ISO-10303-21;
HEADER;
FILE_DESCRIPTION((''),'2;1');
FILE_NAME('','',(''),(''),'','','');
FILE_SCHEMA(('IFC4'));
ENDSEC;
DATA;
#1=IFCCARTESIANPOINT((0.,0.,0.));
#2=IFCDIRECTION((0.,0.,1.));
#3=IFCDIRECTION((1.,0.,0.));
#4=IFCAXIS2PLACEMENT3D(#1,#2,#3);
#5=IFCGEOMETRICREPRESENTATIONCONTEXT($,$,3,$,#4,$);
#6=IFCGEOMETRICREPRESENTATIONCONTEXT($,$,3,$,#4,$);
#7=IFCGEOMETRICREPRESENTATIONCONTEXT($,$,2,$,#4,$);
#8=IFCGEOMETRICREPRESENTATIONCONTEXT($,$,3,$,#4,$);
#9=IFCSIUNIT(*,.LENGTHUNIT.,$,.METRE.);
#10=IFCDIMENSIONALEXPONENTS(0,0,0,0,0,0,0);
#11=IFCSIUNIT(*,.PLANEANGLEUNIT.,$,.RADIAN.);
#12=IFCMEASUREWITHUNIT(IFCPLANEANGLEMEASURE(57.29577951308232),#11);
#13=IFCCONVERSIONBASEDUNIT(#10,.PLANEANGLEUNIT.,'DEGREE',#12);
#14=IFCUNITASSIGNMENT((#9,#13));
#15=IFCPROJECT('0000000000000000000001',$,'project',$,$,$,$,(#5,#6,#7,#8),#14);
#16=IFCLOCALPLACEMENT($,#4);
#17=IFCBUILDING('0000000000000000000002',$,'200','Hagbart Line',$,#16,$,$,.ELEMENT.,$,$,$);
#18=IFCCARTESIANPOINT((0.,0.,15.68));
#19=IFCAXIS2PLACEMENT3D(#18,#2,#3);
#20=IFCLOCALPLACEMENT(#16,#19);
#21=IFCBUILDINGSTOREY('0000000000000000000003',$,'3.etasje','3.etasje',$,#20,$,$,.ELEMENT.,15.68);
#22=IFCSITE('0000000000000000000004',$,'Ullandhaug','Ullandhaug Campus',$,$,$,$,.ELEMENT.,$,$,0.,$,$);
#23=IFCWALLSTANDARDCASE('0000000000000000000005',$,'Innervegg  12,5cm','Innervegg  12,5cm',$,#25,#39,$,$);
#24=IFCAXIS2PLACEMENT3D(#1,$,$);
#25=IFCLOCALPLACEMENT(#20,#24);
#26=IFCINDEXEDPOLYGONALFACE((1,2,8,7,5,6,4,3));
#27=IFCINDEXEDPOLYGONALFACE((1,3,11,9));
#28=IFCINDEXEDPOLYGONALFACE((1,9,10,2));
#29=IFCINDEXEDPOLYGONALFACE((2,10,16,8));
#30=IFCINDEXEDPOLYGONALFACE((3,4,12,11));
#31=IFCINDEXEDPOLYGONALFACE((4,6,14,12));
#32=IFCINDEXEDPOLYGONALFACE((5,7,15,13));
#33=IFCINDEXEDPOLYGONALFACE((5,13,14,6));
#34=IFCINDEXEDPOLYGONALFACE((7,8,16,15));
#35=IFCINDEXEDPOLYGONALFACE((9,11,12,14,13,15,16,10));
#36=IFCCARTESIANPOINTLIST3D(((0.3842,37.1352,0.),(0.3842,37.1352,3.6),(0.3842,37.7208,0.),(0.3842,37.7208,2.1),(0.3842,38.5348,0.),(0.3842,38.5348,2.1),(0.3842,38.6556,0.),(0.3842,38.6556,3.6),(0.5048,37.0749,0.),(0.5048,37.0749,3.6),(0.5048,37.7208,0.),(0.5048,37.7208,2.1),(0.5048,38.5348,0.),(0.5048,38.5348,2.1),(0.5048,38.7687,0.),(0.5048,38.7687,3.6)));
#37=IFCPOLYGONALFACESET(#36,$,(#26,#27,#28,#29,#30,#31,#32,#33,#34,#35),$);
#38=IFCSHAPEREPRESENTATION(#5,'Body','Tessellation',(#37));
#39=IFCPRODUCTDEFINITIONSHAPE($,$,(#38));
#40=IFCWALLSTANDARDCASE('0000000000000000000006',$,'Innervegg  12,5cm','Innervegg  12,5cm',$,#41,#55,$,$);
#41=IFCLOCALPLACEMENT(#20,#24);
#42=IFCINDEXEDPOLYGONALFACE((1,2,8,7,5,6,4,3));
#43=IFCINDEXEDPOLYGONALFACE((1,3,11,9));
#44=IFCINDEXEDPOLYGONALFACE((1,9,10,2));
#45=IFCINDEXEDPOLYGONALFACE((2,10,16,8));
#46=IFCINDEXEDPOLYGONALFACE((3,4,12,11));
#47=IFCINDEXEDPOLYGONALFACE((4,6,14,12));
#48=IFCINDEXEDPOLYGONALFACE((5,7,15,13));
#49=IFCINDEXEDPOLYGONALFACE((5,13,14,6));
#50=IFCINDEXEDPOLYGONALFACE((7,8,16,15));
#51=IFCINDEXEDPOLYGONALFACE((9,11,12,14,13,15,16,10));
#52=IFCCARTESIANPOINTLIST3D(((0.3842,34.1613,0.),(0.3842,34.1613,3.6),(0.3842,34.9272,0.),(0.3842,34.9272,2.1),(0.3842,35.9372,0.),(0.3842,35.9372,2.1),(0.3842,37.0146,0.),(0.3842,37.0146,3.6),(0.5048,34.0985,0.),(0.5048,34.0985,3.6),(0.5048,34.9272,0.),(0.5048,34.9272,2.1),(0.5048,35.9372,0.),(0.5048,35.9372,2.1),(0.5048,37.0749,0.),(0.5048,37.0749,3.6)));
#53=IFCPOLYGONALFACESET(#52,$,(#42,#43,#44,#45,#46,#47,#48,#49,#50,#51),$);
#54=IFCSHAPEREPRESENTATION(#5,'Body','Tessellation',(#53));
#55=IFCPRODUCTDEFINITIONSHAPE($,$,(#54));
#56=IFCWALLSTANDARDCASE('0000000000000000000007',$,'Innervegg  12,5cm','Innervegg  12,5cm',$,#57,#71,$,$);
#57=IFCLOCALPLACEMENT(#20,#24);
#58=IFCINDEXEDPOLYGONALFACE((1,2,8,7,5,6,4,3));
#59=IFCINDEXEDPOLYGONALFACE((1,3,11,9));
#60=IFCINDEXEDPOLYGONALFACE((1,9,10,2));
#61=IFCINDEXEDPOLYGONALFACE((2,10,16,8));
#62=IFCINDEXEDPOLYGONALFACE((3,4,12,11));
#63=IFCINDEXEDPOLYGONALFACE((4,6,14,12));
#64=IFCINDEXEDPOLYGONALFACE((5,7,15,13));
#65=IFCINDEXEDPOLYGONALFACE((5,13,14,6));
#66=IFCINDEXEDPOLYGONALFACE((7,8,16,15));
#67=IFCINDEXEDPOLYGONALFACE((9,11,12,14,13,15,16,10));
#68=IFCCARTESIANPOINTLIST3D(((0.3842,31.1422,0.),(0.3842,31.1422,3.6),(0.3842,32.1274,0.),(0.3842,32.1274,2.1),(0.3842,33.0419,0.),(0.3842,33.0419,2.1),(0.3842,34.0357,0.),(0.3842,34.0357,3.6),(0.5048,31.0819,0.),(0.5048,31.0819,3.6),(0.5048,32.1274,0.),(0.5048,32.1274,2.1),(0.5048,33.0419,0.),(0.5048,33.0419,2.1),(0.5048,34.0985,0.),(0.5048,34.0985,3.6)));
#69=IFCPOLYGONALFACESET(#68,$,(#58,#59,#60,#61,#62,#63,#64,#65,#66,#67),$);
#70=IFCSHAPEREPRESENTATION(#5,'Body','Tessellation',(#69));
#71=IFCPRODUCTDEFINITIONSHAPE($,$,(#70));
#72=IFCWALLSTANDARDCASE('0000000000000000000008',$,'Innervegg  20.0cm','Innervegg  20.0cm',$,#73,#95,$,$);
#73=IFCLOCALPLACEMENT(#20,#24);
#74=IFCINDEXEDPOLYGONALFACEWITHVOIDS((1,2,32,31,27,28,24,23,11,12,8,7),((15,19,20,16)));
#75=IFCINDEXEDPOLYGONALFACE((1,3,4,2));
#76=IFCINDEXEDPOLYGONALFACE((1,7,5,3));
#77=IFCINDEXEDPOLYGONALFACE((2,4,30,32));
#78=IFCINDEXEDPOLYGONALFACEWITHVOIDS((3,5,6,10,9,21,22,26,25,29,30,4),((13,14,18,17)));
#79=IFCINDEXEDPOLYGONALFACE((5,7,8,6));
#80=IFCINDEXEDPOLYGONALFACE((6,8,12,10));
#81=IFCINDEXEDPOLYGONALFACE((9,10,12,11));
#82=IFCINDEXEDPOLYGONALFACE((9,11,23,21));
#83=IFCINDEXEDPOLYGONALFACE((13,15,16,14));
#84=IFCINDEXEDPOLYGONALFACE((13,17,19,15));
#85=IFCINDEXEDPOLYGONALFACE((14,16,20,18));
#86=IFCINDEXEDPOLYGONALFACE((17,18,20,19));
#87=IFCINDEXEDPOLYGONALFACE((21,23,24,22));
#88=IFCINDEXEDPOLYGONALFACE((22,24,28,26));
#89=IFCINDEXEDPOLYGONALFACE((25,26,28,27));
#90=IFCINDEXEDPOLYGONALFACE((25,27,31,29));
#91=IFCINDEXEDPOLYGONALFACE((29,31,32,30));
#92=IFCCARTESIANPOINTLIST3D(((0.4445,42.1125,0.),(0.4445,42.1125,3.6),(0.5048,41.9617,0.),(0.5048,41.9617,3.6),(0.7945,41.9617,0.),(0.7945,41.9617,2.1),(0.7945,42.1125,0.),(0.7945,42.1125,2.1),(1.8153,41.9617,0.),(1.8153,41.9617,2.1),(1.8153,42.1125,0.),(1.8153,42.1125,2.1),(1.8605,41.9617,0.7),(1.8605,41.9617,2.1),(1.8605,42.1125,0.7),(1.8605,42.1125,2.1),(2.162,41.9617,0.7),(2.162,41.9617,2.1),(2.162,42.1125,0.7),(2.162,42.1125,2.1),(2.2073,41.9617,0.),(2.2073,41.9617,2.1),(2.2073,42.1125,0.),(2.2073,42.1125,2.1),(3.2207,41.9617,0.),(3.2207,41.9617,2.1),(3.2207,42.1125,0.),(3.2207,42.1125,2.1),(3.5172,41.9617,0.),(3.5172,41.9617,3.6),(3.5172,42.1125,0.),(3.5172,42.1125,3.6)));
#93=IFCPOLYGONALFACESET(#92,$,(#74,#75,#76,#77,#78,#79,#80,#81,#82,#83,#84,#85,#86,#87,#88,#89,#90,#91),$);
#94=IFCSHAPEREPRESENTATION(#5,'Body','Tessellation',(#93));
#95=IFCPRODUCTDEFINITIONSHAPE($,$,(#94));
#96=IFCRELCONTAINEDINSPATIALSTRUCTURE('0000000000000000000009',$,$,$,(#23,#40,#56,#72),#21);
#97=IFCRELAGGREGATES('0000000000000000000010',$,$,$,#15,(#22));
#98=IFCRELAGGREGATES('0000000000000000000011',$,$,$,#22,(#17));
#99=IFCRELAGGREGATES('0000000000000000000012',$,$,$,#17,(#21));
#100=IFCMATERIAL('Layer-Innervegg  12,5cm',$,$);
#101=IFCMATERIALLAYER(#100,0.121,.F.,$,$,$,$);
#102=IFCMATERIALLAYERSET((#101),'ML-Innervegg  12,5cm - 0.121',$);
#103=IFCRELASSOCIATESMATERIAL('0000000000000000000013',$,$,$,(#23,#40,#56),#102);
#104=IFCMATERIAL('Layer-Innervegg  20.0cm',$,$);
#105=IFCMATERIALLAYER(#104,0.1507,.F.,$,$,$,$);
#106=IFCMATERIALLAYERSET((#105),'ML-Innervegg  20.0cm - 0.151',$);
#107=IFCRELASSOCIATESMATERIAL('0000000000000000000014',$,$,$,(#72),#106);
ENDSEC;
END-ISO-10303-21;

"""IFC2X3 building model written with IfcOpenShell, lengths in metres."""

from ifc_helpers import new_model, entity, si_unit, converted_unit, frame, origin_with_axes, place, context, project, spatial, polyline, outline, extrude, material, layer, layer_set, layer_usage, element, save


model = new_model("IFC2X3")

# Units and contexts
context_of_model_1 = context(None, 3, world=origin_with_axes())
context_of_model_2 = context(None, 3, world=origin_with_axes())
context_of_model_3 = context(None, 2, world=origin_with_axes())
context_of_model_4 = context(None, 3, world=origin_with_axes())
ifc_project = project(units=[si_unit("LENGTHUNIT", "METRE"), converted_unit("PLANEANGLEUNIT", "DEGREE", entity("IfcPlaneAngleMeasure", 57.29577951308232), si_unit("PLANEANGLEUNIT", "RADIAN"), dimensions=[0, 0, 0, 0, 0, 0, 0])], contexts=[context_of_model_1, context_of_model_2, context_of_model_3, context_of_model_4])

# Site, building, storey
site = spatial("IfcSite", under=ifc_project, Name="Ullandhaug", Description="Ullandhaug Campus", CompositionType="ELEMENT", RefElevation=0.0)
building_placement = place(None, origin_with_axes())
building = spatial("IfcBuilding", under=site, at=building_placement, Name="200", Description="Hagbart Line", CompositionType="ELEMENT")
storey_placement = place(building_placement, frame((0.0, 0.0, 15.68), z_axis=(0.0, 0.0, 1.0), x_axis=(1.0, 0.0, 0.0)))
storey = spatial("IfcBuildingStorey", under=building, at=storey_placement, Name="3.etasje", Description="3.etasje", CompositionType="ELEMENT", Elevation=15.68)

# Shared definitions
ifc_material_1 = material(Name="Layer-Innervegg  12,5cm")
ifc_layer_1 = layer(ifc_material_1, 0.121, ventilated=False)
ifc_layer_set_1 = layer_set([ifc_layer_1], Name="ML-Innervegg  12,5cm - 0.121")
ifc_layer_usage_1 = layer_usage(ifc_layer_set_1, "AXIS2", "POSITIVE", 0.0)

# Shared definitions
ifc_material_2 = material(Name="Layer-Innervegg  20.0cm")
ifc_layer_2 = layer(ifc_material_2, 0.1507, ventilated=False)
ifc_layer_set_2 = layer_set([ifc_layer_2], Name="ML-Innervegg  20.0cm - 0.151")
ifc_layer_usage_2 = layer_usage(ifc_layer_set_2, "AXIS2", "POSITIVE", 0.0)

# Walls, openings
wall_1_placement = place(storey_placement, frame((0.5048, 37.0749, 0.0), z_axis=(0.0, 0.0, 1.0), x_axis=(0.0, 1.0, 0.0)))
wall_1 = element("IfcWallStandardCase", 1, at=wall_1_placement, inside=storey, material=ifc_layer_usage_1, Name="Innervegg  12,5cm", Description="Innervegg  12,5cm", context=context_of_model_1, shape_type="SweptSolid", body=[
    extrude(outline(polyline([(0.0, 0.0), (1.6937, 0.0), (1.5807, 0.1206), (0.0603, 0.1206), (0.0, 0.0)])), frame((0.0, 0.0, 0.0), z_axis=(0.0, 0.0, 1.0), x_axis=(1.0, 0.0, 0.0)), (0.0, 0.0, 1.0), 3.6),
])
opening_1_placement = place(wall_1_placement, frame((0.6459, 0.1206, 0.0), z_axis=(0.0, 0.0, 1.0), x_axis=(1.0, 0.0, 0.0)))
element("IfcOpeningElement", 2, at=opening_1_placement, cuts=wall_1, context=context_of_model_1, shape_type="SweptSolid", body=[
    extrude(outline(polyline([(0.0, 0.0), (2.1, 0.0), (2.1, 0.814), (0.0, 0.814), (0.0, 0.0)])), frame((0.0, 0.0, 0.0), z_axis=(0.0, 1.0, 0.0), x_axis=(0.0, 0.0, 1.0)), (0.0, 0.0, -1.0), 0.1206),
])
wall_2_placement = place(storey_placement, frame((0.5048, 34.0985, 0.0), z_axis=(0.0, 0.0, 1.0), x_axis=(0.0, 1.0, 0.0)))
wall_2 = element("IfcWallStandardCase", 3, at=wall_2_placement, inside=storey, material=ifc_layer_usage_1, Name="Innervegg  12,5cm", Description="Innervegg  12,5cm", context=context_of_model_1, shape_type="SweptSolid", body=[
    extrude(outline(polyline([(0.0, 0.0), (2.9765, 0.0), (2.9162, 0.1206), (0.0628, 0.1206), (0.0, 0.0)])), frame((0.0, 0.0, 0.0), z_axis=(0.0, 0.0, 1.0), x_axis=(1.0, 0.0, 0.0)), (0.0, 0.0, 1.0), 3.6),
])
opening_2_placement = place(wall_2_placement, frame((0.8288, 0.1206, 0.0), z_axis=(0.0, 0.0, 1.0), x_axis=(1.0, 0.0, 0.0)))
element("IfcOpeningElement", 4, at=opening_2_placement, cuts=wall_2, context=context_of_model_1, shape_type="SweptSolid", body=[
    extrude(outline(polyline([(0.0, 0.0), (2.1, 0.0), (2.1, 1.01), (0.0, 1.01), (0.0, 0.0)])), frame((0.0, 0.0, 0.0), z_axis=(0.0, 1.0, 0.0), x_axis=(0.0, 0.0, 1.0)), (0.0, 0.0, -1.0), 0.1206),
])
wall_3_placement = place(storey_placement, frame((0.5048, 31.0819, 0.0), z_axis=(0.0, 0.0, 1.0), x_axis=(0.0, 1.0, 0.0)))
wall_3 = element("IfcWallStandardCase", 5, at=wall_3_placement, inside=storey, material=ifc_layer_usage_1, Name="Innervegg  12,5cm", Description="Innervegg  12,5cm", context=context_of_model_1, shape_type="SweptSolid", body=[
    extrude(outline(polyline([(0.0, 0.0), (3.0165, 0.0), (2.9537, 0.1206), (0.0603, 0.1206), (0.0, 0.0)])), frame((0.0, 0.0, 0.0), z_axis=(0.0, 0.0, 1.0), x_axis=(1.0, 0.0, 0.0)), (0.0, 0.0, 1.0), 3.6),
])
opening_3_placement = place(wall_3_placement, frame((1.0455, 0.1206, 0.0), z_axis=(0.0, 0.0, 1.0), x_axis=(1.0, 0.0, 0.0)))
element("IfcOpeningElement", 6, at=opening_3_placement, cuts=wall_3, context=context_of_model_1, shape_type="SweptSolid", body=[
    extrude(outline(polyline([(0.0, 0.0), (2.1, 0.0), (2.1, 0.9145), (0.0, 0.9145), (0.0, 0.0)])), frame((0.0, 0.0, 0.0), z_axis=(0.0, 1.0, 0.0), x_axis=(0.0, 0.0, 1.0)), (0.0, 0.0, -1.0), 0.1206),
])

# Wall, openings
wall_4_placement = place(storey_placement, frame((3.5172, 42.1125, 0.0), z_axis=(0.0, 0.0, 1.0), x_axis=(-1.0, 0.0, 0.0)))
wall_4 = element("IfcWallStandardCase", 7, at=wall_4_placement, inside=storey, material=ifc_layer_usage_2, Name="Innervegg  20.0cm", Description="Innervegg  20.0cm", context=context_of_model_1, shape_type="SweptSolid", body=[
    extrude(outline(polyline([(0.0, 0.0), (3.0727, 0.0), (3.0124, 0.1507), (0.0, 0.1507), (0.0, 0.0)])), frame((0.0, 0.0, 0.0), z_axis=(0.0, 0.0, 1.0), x_axis=(1.0, 0.0, 0.0)), (0.0, 0.0, 1.0), 3.6),
])
opening_4_placement = place(wall_4_placement, frame((1.702, 0.1507, 0.0), z_axis=(0.0, 0.0, 1.0), x_axis=(1.0, 0.0, 0.0)))
element("IfcOpeningElement", 8, at=opening_4_placement, cuts=wall_4, context=context_of_model_1, shape_type="SweptSolid", body=[
    extrude(outline(polyline([(0.0, 0.0), (2.1, 0.0), (2.1, 1.0207), (0.0, 1.0207), (0.0, 0.0)])), frame((0.0, 0.0, 0.0), z_axis=(0.0, 1.0, 0.0), x_axis=(0.0, 0.0, 1.0)), (0.0, 0.0, -1.0), 0.1507),
])
opening_5_placement = place(wall_4_placement, frame((0.2966, 0.1507, 0.0), z_axis=(0.0, 0.0, 1.0), x_axis=(1.0, 0.0, 0.0)))
element("IfcOpeningElement", 9, at=opening_5_placement, cuts=wall_4, context=context_of_model_1, shape_type="SweptSolid", body=[
    extrude(outline(polyline([(0.0, 0.0), (2.1, 0.0), (2.1, 1.0133), (0.0, 1.0133), (0.0, 0.0)])), frame((0.0, 0.0, 0.0), z_axis=(0.0, 1.0, 0.0), x_axis=(0.0, 0.0, 1.0)), (0.0, 0.0, -1.0), 0.1507),
])
opening_6_placement = place(wall_4_placement, frame((1.3552, 0.1507, 0.7), z_axis=(0.0, 0.0, 1.0), x_axis=(1.0, 0.0, 0.0)))
element("IfcOpeningElement", 10, at=opening_6_placement, cuts=wall_4, context=context_of_model_1, shape_type="SweptSolid", body=[
    extrude(outline(polyline([(0.0, 0.0), (1.4, 0.0), (1.4, 0.3015), (0.0, 0.3015), (0.0, 0.0)])), frame((0.0, 0.0, 0.0), z_axis=(0.0, 1.0, 0.0), x_axis=(0.0, 0.0, 1.0)), (0.0, 0.0, -1.0), 0.1507),
])

save(model, "model.ifc")
